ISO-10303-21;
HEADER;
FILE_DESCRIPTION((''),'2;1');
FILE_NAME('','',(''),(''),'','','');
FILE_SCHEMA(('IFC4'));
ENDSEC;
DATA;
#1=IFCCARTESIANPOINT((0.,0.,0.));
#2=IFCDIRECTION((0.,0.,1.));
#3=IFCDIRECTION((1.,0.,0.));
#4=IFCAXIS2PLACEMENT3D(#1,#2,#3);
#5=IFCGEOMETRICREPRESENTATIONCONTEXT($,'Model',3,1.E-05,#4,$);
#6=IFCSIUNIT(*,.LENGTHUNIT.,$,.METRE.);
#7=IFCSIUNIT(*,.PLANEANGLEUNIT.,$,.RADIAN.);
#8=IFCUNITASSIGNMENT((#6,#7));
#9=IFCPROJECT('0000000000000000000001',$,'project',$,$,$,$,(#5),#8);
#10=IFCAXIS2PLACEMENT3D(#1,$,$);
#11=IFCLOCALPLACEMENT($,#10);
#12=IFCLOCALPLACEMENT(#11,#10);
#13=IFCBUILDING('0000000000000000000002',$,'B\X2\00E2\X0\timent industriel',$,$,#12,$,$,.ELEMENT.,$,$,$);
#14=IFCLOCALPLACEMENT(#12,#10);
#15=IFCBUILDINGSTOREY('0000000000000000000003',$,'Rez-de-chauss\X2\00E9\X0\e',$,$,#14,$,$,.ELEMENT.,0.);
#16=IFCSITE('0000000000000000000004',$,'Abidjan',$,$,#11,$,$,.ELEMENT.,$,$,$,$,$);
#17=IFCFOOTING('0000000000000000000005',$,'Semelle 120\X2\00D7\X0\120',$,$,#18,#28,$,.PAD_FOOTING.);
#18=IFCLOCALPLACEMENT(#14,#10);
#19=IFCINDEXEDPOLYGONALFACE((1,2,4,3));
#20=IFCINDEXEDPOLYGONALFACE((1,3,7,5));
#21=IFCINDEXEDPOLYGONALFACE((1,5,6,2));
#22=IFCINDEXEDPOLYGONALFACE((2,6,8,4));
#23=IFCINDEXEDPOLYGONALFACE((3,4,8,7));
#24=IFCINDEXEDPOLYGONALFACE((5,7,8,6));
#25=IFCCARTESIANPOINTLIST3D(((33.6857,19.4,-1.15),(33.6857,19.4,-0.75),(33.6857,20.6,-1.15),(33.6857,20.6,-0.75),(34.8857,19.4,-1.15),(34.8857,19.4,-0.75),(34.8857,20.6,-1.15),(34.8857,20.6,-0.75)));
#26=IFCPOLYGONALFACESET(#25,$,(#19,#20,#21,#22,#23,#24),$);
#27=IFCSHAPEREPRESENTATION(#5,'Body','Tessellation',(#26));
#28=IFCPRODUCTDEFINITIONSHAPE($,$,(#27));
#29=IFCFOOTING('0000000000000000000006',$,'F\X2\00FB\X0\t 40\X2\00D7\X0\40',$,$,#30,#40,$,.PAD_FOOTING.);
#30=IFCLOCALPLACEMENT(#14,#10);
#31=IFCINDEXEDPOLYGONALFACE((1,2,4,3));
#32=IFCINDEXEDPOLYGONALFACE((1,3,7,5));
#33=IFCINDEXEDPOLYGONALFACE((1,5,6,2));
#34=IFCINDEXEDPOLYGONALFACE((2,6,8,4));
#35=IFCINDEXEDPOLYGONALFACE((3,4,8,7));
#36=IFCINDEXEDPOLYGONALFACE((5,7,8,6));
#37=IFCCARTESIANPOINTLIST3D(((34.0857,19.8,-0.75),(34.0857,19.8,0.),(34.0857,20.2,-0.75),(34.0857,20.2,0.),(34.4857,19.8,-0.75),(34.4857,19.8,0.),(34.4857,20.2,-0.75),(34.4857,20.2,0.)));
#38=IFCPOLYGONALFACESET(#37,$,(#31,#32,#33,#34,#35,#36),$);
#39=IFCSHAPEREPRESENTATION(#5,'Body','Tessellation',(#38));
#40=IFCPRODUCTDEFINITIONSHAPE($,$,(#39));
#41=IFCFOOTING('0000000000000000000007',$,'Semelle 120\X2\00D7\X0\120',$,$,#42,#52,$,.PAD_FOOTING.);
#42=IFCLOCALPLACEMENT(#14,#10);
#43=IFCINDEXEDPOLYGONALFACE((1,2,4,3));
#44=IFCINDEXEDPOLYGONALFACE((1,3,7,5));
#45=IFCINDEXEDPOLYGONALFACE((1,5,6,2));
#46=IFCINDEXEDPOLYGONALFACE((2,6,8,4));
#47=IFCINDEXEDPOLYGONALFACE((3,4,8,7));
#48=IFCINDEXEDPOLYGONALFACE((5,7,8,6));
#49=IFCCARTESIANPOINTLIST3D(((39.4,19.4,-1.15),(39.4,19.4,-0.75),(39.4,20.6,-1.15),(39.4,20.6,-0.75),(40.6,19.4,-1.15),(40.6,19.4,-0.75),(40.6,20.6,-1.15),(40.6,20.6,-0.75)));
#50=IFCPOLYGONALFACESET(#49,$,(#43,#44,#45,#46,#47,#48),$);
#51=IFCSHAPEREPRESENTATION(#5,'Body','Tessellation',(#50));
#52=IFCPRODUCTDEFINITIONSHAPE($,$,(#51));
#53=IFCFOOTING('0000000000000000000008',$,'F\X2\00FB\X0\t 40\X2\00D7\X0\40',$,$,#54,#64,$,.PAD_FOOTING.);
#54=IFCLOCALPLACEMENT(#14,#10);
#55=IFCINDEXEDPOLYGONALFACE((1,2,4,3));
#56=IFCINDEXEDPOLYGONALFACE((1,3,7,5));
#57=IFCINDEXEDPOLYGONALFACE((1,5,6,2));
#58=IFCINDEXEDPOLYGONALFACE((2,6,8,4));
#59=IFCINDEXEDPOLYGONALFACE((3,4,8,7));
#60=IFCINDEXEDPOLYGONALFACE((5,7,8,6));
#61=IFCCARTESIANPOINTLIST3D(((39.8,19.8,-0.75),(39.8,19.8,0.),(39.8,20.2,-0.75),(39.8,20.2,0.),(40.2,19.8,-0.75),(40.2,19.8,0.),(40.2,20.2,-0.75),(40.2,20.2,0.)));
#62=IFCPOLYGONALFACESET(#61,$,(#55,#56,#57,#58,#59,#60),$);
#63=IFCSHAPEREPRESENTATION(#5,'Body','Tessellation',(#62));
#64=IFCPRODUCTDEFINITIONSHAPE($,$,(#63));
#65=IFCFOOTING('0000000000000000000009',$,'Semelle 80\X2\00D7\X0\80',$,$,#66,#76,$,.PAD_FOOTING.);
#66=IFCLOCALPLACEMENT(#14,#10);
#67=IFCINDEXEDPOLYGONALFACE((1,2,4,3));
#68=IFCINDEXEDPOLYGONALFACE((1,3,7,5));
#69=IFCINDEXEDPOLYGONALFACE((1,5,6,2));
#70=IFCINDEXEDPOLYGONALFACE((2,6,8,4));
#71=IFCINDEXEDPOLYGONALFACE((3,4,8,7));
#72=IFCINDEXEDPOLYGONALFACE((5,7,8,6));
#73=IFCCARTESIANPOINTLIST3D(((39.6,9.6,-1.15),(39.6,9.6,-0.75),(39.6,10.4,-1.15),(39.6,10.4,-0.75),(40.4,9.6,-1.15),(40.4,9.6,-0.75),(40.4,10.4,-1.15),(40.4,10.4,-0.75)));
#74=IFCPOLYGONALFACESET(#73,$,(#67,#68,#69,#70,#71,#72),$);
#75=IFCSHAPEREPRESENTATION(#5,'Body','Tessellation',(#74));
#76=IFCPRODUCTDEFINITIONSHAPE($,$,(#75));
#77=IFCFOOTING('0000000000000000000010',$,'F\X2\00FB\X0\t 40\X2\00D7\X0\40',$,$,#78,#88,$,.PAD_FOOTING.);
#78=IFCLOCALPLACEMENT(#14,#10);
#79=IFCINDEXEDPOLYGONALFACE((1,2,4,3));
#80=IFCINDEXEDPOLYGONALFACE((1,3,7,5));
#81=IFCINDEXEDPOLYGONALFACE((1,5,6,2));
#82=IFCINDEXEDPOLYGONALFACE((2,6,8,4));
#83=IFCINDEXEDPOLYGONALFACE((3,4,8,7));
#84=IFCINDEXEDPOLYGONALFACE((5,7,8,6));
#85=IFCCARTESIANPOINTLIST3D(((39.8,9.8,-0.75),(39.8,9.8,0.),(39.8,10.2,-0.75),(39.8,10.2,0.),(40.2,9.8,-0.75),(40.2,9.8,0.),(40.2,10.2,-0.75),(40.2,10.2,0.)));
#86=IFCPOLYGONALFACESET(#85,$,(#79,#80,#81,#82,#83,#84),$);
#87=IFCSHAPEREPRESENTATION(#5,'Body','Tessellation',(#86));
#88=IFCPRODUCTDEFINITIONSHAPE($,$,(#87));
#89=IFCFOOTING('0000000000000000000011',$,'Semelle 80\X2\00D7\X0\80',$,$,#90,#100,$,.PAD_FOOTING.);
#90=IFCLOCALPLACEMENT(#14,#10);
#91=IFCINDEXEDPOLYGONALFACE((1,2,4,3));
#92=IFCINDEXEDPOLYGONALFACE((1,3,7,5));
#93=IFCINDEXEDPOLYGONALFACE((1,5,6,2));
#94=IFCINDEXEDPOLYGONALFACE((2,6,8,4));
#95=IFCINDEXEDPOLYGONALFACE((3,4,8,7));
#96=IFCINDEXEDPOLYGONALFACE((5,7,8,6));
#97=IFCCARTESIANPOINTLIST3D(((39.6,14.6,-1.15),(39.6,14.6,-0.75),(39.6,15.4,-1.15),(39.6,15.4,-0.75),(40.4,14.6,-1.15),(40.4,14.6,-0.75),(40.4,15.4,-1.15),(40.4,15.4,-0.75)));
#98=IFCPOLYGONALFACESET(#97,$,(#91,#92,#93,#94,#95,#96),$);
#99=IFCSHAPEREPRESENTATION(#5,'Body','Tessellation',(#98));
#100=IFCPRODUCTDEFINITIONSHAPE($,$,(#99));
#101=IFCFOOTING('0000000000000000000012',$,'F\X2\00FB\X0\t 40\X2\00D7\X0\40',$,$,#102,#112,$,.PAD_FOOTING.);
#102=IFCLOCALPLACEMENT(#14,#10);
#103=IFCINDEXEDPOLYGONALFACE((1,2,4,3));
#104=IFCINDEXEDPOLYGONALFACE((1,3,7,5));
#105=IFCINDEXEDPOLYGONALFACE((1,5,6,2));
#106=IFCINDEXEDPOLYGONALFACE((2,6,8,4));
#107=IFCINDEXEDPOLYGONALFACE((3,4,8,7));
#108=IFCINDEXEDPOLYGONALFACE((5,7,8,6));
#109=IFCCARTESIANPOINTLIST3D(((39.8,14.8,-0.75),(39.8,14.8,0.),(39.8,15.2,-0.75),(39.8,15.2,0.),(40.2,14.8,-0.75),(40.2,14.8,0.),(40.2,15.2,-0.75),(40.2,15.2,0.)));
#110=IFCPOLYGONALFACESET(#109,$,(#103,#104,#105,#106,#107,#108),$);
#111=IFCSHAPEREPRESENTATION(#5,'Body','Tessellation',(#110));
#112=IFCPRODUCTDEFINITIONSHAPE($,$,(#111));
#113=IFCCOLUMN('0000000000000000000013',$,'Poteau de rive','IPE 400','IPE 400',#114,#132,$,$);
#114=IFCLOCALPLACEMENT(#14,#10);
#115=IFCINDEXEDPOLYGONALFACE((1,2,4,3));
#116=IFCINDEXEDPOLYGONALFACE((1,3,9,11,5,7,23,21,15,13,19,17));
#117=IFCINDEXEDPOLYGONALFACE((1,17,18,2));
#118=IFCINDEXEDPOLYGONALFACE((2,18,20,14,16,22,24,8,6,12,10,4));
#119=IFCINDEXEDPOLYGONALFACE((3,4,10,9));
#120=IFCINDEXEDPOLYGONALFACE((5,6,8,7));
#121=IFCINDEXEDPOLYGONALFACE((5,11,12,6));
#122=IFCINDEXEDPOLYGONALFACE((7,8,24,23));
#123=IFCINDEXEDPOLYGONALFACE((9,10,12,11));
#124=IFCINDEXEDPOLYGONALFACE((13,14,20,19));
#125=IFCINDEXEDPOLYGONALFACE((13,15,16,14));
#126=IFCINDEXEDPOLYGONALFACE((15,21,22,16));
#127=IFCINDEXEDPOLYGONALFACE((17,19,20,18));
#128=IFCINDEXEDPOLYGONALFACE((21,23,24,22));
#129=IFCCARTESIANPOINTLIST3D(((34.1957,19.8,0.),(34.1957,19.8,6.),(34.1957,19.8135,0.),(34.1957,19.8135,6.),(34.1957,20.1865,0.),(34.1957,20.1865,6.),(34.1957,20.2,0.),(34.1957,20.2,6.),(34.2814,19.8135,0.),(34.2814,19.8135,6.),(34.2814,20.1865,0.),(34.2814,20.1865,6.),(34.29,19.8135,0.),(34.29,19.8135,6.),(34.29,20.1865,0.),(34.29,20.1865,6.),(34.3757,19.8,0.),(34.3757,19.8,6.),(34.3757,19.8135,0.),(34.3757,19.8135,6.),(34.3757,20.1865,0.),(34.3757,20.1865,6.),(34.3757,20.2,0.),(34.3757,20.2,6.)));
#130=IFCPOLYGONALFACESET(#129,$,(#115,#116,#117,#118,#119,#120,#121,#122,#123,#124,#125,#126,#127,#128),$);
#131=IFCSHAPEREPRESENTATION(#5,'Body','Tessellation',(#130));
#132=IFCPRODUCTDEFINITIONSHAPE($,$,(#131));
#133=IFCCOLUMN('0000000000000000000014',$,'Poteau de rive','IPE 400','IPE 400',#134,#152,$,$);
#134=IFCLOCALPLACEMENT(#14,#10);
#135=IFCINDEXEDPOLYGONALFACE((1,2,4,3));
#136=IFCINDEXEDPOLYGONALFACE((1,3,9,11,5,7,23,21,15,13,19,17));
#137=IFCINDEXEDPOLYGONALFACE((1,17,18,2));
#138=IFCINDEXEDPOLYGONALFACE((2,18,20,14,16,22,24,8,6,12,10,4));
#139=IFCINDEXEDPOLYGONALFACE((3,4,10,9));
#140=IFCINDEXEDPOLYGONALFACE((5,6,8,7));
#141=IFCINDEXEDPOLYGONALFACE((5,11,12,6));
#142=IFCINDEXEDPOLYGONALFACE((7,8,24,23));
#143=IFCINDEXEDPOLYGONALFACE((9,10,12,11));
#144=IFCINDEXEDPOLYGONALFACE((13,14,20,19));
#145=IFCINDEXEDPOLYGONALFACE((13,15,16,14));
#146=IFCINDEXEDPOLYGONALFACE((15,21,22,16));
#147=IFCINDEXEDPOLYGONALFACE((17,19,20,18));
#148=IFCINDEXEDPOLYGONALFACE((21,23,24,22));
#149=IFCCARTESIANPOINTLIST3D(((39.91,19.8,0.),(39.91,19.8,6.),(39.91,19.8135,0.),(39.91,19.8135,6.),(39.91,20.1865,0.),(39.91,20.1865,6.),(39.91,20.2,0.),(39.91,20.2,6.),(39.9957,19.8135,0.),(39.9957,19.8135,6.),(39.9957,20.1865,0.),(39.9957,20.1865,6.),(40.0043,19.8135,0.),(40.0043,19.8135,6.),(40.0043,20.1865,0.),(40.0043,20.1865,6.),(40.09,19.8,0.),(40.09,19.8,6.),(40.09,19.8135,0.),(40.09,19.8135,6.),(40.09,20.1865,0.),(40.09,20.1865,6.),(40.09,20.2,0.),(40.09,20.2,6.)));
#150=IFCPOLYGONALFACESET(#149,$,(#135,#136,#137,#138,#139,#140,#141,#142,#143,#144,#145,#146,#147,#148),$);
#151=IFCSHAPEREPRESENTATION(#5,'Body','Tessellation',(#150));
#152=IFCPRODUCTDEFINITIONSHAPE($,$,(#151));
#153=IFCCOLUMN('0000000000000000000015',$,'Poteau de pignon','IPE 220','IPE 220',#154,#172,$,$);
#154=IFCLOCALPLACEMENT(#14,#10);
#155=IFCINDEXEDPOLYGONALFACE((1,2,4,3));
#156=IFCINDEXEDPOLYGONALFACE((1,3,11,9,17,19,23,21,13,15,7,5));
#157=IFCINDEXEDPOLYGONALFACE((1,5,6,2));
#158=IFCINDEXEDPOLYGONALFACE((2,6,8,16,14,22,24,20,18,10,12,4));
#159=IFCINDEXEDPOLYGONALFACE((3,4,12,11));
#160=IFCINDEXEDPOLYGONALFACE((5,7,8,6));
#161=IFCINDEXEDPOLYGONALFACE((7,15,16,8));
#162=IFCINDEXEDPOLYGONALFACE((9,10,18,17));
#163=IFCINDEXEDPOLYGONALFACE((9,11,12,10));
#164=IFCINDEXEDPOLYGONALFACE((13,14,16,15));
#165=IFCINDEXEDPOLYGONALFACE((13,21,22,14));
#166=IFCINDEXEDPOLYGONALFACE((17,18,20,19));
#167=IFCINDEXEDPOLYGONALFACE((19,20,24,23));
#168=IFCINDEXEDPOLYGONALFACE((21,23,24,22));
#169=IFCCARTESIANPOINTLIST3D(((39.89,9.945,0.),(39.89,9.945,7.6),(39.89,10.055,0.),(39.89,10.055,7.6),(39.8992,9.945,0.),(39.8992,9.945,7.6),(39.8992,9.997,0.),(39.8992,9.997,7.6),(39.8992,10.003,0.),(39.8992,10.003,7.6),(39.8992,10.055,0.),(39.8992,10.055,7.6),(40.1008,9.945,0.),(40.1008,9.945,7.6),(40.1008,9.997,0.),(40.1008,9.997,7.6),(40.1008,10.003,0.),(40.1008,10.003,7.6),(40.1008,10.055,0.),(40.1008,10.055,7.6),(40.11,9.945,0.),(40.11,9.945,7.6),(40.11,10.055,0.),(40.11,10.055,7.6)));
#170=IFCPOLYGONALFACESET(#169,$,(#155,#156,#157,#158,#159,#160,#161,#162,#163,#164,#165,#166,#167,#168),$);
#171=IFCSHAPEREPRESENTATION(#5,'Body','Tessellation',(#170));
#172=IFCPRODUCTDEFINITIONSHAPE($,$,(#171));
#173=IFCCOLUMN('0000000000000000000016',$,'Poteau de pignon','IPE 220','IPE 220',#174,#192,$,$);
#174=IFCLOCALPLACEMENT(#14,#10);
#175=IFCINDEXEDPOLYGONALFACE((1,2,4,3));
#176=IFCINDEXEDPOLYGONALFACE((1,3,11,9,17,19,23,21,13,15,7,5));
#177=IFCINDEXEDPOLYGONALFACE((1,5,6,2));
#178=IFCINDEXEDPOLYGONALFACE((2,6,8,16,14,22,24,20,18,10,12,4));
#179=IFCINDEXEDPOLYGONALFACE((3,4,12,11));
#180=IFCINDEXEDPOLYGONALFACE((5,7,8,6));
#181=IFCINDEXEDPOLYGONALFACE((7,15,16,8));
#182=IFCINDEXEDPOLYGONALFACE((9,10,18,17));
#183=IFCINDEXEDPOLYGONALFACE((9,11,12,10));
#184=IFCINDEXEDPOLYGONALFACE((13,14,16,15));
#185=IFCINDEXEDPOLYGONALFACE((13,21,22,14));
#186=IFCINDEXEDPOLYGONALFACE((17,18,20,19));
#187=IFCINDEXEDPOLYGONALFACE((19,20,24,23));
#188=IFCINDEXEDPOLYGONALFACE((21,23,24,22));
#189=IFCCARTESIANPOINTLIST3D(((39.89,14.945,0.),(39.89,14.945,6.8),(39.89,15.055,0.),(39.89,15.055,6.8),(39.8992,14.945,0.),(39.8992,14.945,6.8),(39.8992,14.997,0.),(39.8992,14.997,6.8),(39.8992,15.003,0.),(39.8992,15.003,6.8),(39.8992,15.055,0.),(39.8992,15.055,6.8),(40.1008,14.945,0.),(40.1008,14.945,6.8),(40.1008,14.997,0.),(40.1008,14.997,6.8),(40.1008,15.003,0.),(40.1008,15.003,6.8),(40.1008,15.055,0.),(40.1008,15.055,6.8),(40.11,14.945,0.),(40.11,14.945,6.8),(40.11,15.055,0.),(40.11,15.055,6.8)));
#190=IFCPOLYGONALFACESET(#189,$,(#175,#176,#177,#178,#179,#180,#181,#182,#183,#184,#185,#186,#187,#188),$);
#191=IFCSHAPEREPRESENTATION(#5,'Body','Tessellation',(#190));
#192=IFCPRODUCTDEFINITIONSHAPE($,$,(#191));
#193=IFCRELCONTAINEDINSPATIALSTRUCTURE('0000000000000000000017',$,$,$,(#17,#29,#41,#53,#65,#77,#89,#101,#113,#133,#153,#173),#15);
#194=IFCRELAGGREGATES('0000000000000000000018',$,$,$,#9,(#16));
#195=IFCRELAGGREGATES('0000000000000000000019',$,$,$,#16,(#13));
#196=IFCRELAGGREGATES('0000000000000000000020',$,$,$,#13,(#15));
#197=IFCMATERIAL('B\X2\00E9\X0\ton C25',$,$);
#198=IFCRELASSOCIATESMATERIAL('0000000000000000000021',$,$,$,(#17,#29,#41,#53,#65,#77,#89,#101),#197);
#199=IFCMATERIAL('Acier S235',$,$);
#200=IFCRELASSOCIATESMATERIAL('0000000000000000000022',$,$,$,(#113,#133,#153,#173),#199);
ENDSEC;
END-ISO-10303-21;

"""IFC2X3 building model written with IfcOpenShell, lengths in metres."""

from ifc_helpers import new_model, si_unit, frame, origin, origin_with_axes, origin_2d, place, context, project, spatial, rectangle, i_section, extrude, material, element, save


model = new_model("IFC2X3")

# Units and contexts
model_context = context("Model", 3, precision=1e-05, world=origin_with_axes())
ifc_project = project(units=[si_unit("LENGTHUNIT", "METRE"), si_unit("PLANEANGLEUNIT", "RADIAN")], contexts=[model_context])

# Site, building, storey
site_placement = place(None, origin())
site = spatial("IfcSite", under=ifc_project, at=site_placement, Name="Abidjan", CompositionType="ELEMENT")
building_placement = place(site_placement, origin())
building = spatial("IfcBuilding", under=site, at=building_placement, Name="Bâtiment industriel", CompositionType="ELEMENT")
storey_placement = place(building_placement, origin())
storey = spatial("IfcBuildingStorey", under=building, at=storey_placement, Name="Rez-de-chaussée", CompositionType="ELEMENT", Elevation=0.0)

# Footings
ifc_material_1 = material(Name="Béton C25")
footing_1_placement = place(storey_placement, frame((34.2857, 20.0, -1.15), z_axis=(0.0, 0.0, 1.0), x_axis=(1.0, 0.0, 0.0)))
element("IfcFooting", 1, at=footing_1_placement, inside=storey, material=ifc_material_1, Name="Semelle 120×120", PredefinedType="PAD_FOOTING", context=model_context, shape_type="SweptSolid", body=[
    extrude(rectangle(XDim=1.2, YDim=1.2, at=origin_2d()), origin(), (0.0, 0.0, 1.0), 0.4),
])
footing_2_placement = place(storey_placement, frame((34.2857, 20.0, -0.75), z_axis=(0.0, 0.0, 1.0), x_axis=(1.0, 0.0, 0.0)))
element("IfcFooting", 2, at=footing_2_placement, inside=storey, material=ifc_material_1, Name="Fût 40×40", PredefinedType="PAD_FOOTING", context=model_context, shape_type="SweptSolid", body=[
    extrude(rectangle(XDim=0.4, YDim=0.4, at=origin_2d()), origin(), (0.0, 0.0, 1.0), 0.75),
])
footing_3_placement = place(storey_placement, frame((40.0, 20.0, -1.15), z_axis=(0.0, 0.0, 1.0), x_axis=(1.0, 0.0, 0.0)))
element("IfcFooting", 3, at=footing_3_placement, inside=storey, material=ifc_material_1, Name="Semelle 120×120", PredefinedType="PAD_FOOTING", context=model_context, shape_type="SweptSolid", body=[
    extrude(rectangle(XDim=1.2, YDim=1.2, at=origin_2d()), origin(), (0.0, 0.0, 1.0), 0.4),
])
footing_4_placement = place(storey_placement, frame((40.0, 20.0, -0.75), z_axis=(0.0, 0.0, 1.0), x_axis=(1.0, 0.0, 0.0)))
element("IfcFooting", 4, at=footing_4_placement, inside=storey, material=ifc_material_1, Name="Fût 40×40", PredefinedType="PAD_FOOTING", context=model_context, shape_type="SweptSolid", body=[
    extrude(rectangle(XDim=0.4, YDim=0.4, at=origin_2d()), origin(), (0.0, 0.0, 1.0), 0.75),
])
footing_5_placement = place(storey_placement, frame((40.0, 10.0, -1.15), z_axis=(0.0, 0.0, 1.0), x_axis=(1.0, 0.0, 0.0)))
element("IfcFooting", 5, at=footing_5_placement, inside=storey, material=ifc_material_1, Name="Semelle 80×80", PredefinedType="PAD_FOOTING", context=model_context, shape_type="SweptSolid", body=[
    extrude(rectangle(XDim=0.8, YDim=0.8, at=origin_2d()), origin(), (0.0, 0.0, 1.0), 0.4),
])
footing_6_placement = place(storey_placement, frame((40.0, 10.0, -0.75), z_axis=(0.0, 0.0, 1.0), x_axis=(1.0, 0.0, 0.0)))
element("IfcFooting", 6, at=footing_6_placement, inside=storey, material=ifc_material_1, Name="Fût 40×40", PredefinedType="PAD_FOOTING", context=model_context, shape_type="SweptSolid", body=[
    extrude(rectangle(XDim=0.4, YDim=0.4, at=origin_2d()), origin(), (0.0, 0.0, 1.0), 0.75),
])
footing_7_placement = place(storey_placement, frame((40.0, 15.0, -1.15), z_axis=(0.0, 0.0, 1.0), x_axis=(1.0, 0.0, 0.0)))
element("IfcFooting", 7, at=footing_7_placement, inside=storey, material=ifc_material_1, Name="Semelle 80×80", PredefinedType="PAD_FOOTING", context=model_context, shape_type="SweptSolid", body=[
    extrude(rectangle(XDim=0.8, YDim=0.8, at=origin_2d()), origin(), (0.0, 0.0, 1.0), 0.4),
])
footing_8_placement = place(storey_placement, frame((40.0, 15.0, -0.75), z_axis=(0.0, 0.0, 1.0), x_axis=(1.0, 0.0, 0.0)))
element("IfcFooting", 8, at=footing_8_placement, inside=storey, material=ifc_material_1, Name="Fût 40×40", PredefinedType="PAD_FOOTING", context=model_context, shape_type="SweptSolid", body=[
    extrude(rectangle(XDim=0.4, YDim=0.4, at=origin_2d()), origin(), (0.0, 0.0, 1.0), 0.75),
])

# Columns
ifc_material_2 = material(Name="Acier S235")
for number, where, z_axis, x_axis, name in (
    (9, (34.2857, 20.0, 0.0), (0.0, 0.0, 1.0), (1.0, 0.0, 0.0), "Poteau de rive"),
    (10, (40.0, 20.0, 0.0), (0.0, 0.0, 1.0), (1.0, 0.0, 0.0), "Poteau de rive"),
):
    element("IfcColumn", number, at=place(storey_placement, frame(where, z_axis=z_axis, x_axis=x_axis)), inside=storey, material=ifc_material_2, Name=name, Description="IPE 400", ObjectType="IPE 400", context=model_context, shape_type="SweptSolid", body=[
        extrude(i_section(OverallWidth=0.18, OverallDepth=0.4, WebThickness=0.0086, FlangeThickness=0.0135, at=origin_2d()), origin(), (0.0, 0.0, 1.0), 6.0),
    ])
column_1_placement = place(storey_placement, frame((40.0, 10.0, 0.0), z_axis=(0.0, 0.0, 1.0), x_axis=(0.0, 1.0, 0.0)))
element("IfcColumn", 11, at=column_1_placement, inside=storey, material=ifc_material_2, Name="Poteau de pignon", Description="IPE 220", ObjectType="IPE 220", context=model_context, shape_type="SweptSolid", body=[
    extrude(i_section(OverallWidth=0.11, OverallDepth=0.22, WebThickness=0.0059, FlangeThickness=0.0092, at=origin_2d()), origin(), (0.0, 0.0, 1.0), 7.6),
])
column_2_placement = place(storey_placement, frame((40.0, 15.0, 0.0), z_axis=(0.0, 0.0, 1.0), x_axis=(0.0, 1.0, 0.0)))
element("IfcColumn", 12, at=column_2_placement, inside=storey, material=ifc_material_2, Name="Poteau de pignon", Description="IPE 220", ObjectType="IPE 220", context=model_context, shape_type="SweptSolid", body=[
    extrude(i_section(OverallWidth=0.11, OverallDepth=0.22, WebThickness=0.0059, FlangeThickness=0.0092, at=origin_2d()), origin(), (0.0, 0.0, 1.0), 6.8),
])

save(model, "model.ifc")
